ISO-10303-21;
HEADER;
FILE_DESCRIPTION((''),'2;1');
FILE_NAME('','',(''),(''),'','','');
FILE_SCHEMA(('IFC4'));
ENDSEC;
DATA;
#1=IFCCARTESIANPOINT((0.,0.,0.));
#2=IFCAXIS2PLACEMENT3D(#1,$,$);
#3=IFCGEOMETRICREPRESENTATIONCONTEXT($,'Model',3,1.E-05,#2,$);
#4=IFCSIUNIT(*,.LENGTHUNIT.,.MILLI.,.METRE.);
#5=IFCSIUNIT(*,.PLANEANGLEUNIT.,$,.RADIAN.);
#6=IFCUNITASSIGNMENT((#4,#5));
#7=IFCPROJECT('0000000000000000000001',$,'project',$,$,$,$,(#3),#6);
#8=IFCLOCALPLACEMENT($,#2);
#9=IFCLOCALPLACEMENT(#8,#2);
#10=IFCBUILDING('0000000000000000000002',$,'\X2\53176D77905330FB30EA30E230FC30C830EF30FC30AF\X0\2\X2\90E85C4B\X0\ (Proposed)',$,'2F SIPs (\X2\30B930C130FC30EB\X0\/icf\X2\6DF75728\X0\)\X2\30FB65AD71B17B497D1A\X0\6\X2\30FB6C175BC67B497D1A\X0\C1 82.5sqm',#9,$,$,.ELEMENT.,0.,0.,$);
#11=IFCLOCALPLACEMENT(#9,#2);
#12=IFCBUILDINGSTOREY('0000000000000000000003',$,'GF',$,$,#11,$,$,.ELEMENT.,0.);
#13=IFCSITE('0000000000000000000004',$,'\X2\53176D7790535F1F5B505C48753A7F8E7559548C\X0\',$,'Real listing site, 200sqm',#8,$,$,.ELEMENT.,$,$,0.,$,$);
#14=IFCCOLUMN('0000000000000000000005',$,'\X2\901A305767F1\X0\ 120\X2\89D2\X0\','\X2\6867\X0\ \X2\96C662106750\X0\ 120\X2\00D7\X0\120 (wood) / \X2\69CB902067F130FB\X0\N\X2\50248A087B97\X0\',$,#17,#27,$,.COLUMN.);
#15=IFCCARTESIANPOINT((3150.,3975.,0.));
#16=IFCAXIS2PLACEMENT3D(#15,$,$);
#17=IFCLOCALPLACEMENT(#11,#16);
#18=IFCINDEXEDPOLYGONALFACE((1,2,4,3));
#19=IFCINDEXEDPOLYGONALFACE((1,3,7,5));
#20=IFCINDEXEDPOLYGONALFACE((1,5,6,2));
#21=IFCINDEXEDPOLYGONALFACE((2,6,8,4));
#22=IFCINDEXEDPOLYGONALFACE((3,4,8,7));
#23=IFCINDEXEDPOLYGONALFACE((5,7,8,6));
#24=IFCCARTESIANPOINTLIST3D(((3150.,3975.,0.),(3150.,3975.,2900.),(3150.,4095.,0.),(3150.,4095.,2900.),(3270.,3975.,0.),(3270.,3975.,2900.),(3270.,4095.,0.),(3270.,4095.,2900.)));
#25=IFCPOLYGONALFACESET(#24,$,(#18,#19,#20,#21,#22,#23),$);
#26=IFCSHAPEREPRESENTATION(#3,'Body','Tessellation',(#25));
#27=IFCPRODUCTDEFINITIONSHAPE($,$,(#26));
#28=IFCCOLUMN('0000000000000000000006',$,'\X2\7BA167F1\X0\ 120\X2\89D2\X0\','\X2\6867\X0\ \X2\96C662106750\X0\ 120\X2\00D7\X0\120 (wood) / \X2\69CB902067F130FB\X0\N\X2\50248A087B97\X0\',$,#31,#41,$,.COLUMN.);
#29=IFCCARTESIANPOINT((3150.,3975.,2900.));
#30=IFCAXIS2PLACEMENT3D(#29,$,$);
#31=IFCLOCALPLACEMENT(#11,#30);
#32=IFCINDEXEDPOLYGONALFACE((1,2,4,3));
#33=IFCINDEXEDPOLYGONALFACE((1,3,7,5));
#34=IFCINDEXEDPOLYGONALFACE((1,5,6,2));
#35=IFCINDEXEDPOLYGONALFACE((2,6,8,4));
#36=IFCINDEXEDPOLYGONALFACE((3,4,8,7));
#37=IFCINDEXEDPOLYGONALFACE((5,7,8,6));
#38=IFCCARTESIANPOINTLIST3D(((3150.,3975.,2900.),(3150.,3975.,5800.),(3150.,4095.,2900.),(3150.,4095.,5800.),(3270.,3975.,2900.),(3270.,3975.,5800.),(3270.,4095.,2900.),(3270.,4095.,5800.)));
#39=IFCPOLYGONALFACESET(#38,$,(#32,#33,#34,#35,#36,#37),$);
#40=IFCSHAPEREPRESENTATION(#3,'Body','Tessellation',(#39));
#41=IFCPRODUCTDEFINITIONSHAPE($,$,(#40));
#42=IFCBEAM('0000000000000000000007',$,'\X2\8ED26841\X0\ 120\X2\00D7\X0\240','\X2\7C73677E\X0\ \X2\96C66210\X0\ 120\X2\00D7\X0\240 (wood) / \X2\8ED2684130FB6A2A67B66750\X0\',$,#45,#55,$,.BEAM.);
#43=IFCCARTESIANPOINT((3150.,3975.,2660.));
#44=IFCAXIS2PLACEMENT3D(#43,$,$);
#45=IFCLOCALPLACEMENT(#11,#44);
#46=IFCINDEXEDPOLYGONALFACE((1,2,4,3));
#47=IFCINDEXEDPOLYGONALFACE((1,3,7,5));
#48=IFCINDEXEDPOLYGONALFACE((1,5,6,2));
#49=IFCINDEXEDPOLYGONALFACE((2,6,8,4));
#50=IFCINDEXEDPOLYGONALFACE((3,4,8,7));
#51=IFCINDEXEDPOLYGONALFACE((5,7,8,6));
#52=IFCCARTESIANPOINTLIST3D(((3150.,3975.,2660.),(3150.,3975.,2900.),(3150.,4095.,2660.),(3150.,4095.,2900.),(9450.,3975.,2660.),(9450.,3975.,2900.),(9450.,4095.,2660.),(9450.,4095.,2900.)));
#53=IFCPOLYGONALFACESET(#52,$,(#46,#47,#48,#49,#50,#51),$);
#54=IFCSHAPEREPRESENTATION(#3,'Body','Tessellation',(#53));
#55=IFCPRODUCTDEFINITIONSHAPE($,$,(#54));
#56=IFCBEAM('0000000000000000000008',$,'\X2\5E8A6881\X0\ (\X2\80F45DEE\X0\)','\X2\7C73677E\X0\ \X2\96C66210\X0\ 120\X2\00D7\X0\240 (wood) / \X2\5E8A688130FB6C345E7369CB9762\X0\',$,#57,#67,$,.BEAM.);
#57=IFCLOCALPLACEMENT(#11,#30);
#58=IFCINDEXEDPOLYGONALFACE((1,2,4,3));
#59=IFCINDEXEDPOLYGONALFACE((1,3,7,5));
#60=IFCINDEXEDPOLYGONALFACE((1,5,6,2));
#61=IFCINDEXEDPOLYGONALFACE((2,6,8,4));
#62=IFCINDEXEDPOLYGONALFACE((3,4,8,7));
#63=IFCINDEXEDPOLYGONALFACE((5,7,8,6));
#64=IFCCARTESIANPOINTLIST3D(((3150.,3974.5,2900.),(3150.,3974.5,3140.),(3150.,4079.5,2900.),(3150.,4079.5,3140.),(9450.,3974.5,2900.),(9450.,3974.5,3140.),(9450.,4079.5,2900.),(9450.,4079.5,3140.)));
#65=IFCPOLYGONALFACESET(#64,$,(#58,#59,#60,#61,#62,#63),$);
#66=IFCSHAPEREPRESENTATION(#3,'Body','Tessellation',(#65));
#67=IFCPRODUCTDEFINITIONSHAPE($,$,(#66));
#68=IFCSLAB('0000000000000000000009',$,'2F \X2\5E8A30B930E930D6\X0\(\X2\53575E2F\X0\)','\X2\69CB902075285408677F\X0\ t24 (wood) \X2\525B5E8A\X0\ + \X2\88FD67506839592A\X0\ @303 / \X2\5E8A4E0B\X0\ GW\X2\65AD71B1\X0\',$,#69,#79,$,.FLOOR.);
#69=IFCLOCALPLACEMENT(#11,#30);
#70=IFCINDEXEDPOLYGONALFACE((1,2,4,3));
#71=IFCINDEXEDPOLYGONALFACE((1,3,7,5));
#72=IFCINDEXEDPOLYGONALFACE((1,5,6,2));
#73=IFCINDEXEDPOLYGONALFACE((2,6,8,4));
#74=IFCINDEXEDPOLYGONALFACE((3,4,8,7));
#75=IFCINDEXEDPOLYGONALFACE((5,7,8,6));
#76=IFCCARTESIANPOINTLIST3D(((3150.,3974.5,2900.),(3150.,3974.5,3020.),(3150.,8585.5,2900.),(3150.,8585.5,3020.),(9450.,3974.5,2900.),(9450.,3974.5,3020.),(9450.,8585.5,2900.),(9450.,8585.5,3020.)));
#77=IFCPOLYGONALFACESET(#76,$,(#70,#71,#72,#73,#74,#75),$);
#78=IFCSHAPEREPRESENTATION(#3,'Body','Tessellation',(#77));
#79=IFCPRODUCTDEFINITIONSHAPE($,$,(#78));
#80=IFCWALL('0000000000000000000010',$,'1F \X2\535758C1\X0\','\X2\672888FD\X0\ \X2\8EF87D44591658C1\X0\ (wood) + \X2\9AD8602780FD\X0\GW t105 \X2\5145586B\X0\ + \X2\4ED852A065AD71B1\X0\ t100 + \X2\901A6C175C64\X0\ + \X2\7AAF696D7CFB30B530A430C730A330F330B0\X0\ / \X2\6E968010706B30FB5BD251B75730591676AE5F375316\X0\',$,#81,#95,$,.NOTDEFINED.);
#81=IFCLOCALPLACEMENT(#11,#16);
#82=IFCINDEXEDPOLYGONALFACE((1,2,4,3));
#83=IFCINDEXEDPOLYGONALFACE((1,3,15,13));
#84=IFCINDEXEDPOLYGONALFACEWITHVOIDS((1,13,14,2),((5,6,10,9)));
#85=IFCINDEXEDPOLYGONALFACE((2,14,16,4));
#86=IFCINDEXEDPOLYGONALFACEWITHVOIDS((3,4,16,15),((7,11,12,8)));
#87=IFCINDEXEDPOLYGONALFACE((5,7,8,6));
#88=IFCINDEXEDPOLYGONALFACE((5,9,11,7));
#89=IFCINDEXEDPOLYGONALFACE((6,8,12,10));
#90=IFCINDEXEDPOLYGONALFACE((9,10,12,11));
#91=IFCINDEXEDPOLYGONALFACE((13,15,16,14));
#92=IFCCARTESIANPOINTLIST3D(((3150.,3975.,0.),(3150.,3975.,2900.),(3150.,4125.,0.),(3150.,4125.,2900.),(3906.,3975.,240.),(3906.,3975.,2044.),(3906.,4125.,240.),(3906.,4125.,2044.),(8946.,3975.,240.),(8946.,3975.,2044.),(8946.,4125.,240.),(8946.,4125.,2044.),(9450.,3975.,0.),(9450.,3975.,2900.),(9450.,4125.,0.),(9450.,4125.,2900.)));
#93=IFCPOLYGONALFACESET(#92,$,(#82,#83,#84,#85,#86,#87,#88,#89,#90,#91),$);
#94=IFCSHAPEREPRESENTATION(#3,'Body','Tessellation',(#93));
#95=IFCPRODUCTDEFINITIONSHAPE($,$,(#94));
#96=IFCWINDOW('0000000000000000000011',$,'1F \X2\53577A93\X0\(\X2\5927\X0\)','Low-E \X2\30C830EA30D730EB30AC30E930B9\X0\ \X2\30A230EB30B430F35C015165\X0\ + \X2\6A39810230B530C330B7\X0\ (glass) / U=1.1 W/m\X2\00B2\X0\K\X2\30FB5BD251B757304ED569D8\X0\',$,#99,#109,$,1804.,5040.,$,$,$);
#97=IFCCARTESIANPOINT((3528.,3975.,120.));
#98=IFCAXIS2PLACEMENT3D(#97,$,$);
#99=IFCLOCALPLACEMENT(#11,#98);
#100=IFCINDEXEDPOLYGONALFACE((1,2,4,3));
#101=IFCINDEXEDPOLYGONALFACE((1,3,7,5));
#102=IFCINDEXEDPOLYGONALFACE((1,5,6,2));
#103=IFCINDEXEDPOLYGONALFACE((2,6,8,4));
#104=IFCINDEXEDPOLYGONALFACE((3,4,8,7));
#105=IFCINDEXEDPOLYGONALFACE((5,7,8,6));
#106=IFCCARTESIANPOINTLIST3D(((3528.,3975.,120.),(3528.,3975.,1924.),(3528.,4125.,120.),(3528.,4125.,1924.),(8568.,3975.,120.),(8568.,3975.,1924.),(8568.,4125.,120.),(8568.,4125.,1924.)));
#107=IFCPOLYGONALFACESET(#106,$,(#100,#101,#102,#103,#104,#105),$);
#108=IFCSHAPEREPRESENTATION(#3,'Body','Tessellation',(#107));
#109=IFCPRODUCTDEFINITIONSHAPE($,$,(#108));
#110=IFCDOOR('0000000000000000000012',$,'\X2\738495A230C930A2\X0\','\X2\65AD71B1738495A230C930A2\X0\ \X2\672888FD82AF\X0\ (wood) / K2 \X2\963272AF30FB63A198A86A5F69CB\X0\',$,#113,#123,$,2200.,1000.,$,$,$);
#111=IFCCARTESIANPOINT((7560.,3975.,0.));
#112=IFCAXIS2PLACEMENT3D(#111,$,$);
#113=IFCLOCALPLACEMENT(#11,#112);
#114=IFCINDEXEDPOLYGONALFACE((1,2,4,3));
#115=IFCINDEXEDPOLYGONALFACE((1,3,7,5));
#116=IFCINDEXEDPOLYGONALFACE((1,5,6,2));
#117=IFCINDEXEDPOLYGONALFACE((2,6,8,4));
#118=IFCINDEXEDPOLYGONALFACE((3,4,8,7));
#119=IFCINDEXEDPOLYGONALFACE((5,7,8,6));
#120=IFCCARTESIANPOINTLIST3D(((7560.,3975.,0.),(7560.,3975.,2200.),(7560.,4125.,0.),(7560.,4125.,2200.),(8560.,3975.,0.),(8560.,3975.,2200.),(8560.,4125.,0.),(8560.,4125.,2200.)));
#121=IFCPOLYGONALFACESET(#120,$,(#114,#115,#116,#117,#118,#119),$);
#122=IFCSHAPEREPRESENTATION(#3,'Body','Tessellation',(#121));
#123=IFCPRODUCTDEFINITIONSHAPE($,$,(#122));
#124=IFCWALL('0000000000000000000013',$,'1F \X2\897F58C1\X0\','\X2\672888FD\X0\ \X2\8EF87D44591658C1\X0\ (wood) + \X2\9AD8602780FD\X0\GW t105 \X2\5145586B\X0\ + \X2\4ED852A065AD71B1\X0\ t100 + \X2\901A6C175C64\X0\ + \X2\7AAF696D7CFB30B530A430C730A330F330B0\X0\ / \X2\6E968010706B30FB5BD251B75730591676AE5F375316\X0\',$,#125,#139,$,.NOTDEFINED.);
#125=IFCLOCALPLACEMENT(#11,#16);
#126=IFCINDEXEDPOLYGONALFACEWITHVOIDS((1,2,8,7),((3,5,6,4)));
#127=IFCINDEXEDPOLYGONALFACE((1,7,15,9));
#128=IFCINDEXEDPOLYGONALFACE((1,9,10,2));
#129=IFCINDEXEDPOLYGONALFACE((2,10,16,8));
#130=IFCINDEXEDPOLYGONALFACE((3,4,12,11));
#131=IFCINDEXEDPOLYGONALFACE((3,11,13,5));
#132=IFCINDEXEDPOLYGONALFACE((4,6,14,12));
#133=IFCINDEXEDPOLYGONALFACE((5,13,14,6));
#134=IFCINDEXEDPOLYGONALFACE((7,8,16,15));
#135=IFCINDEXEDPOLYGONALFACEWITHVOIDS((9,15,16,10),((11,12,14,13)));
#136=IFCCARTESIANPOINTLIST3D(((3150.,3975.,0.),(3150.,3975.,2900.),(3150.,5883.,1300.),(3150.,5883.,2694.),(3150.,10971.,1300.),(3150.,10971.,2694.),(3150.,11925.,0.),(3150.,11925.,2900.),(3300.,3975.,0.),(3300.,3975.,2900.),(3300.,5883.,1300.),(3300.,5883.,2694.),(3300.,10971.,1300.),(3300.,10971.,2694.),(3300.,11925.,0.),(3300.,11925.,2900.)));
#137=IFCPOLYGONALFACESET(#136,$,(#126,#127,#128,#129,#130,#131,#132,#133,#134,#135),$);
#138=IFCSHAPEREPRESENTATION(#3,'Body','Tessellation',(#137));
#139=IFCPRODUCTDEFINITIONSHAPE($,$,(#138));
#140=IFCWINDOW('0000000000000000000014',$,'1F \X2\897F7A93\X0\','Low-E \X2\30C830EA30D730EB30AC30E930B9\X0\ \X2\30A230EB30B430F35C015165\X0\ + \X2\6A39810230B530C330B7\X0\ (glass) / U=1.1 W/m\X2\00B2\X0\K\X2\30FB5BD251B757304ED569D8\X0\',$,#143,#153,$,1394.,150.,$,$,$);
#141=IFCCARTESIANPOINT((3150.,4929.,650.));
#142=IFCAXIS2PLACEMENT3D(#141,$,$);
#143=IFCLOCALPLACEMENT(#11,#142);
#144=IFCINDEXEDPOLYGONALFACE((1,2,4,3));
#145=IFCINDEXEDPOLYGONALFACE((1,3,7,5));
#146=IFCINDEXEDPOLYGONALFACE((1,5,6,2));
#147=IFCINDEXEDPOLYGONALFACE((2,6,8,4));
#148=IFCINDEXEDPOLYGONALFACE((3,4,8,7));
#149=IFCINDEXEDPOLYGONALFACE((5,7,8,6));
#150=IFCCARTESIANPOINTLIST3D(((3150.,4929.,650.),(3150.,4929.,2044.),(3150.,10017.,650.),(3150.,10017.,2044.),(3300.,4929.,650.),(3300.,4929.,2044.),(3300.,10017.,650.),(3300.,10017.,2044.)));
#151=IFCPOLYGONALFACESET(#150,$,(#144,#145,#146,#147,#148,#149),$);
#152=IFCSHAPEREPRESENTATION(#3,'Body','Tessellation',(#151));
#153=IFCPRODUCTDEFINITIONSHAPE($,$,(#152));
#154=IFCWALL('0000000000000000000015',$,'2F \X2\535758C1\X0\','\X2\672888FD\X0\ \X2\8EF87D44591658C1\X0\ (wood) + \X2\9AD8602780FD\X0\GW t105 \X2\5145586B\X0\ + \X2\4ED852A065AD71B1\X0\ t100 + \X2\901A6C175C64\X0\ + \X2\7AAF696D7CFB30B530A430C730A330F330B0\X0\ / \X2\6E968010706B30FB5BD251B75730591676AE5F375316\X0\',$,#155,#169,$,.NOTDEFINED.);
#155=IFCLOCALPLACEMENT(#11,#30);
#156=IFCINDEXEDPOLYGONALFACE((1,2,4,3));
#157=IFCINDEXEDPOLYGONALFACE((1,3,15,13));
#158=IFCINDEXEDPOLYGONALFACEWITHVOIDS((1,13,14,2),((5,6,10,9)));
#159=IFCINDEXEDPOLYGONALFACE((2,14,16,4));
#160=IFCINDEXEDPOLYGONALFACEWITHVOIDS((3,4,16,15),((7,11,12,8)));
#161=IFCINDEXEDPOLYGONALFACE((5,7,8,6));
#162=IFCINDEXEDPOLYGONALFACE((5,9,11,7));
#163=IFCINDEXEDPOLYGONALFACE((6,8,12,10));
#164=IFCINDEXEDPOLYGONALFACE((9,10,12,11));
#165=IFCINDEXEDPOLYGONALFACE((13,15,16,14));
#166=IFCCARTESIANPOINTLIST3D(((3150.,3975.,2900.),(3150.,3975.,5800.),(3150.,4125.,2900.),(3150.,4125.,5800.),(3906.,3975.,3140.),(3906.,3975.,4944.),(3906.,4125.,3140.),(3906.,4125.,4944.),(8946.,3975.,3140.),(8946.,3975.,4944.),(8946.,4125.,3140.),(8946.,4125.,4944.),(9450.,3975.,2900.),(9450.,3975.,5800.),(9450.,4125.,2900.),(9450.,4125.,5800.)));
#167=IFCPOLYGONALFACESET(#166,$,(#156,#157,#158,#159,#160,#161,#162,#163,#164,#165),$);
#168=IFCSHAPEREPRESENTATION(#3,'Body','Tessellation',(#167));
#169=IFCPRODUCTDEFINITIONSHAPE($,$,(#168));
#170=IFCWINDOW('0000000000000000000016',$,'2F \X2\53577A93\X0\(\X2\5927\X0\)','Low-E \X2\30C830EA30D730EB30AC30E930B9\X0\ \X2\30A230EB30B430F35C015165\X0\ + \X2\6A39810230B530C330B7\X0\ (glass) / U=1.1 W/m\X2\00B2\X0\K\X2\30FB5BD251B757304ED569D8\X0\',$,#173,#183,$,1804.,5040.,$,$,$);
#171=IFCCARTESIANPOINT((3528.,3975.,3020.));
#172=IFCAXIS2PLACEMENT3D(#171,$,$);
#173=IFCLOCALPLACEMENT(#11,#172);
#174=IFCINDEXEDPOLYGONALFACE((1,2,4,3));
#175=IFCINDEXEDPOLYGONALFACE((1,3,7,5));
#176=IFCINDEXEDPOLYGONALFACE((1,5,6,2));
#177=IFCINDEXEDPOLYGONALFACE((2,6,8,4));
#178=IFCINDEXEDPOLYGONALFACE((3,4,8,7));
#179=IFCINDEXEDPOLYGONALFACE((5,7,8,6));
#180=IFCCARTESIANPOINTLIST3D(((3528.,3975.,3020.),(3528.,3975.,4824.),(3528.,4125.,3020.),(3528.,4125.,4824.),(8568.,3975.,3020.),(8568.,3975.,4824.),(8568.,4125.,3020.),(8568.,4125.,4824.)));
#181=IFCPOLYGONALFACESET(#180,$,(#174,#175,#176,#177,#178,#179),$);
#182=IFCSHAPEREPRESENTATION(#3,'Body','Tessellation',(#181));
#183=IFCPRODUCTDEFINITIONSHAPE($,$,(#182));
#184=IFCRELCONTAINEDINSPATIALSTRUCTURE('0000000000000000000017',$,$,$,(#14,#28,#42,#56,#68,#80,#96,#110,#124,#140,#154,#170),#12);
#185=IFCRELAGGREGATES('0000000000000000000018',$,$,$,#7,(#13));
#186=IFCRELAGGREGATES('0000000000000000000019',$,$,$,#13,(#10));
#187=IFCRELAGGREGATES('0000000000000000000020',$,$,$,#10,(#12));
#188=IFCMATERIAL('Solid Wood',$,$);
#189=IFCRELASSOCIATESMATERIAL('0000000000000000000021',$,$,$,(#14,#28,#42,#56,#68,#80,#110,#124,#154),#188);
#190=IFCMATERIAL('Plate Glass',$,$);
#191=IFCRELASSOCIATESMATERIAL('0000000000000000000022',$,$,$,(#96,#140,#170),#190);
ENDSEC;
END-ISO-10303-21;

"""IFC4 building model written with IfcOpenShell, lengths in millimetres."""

from ifc_helpers import new_model, si_unit, frame, frame_2d, origin, place, context, project, spatial, rectangle, extrude, material, element, fill, save


model = new_model("IFC4")

# Units and contexts
model_context = context("Model", 3, precision=1e-05, world=origin())
ifc_project = project(units=[si_unit("LENGTHUNIT", "METRE", prefix="MILLI"), si_unit("PLANEANGLEUNIT", "RADIAN")], contexts=[model_context])

# Site, building, storey
site_placement = place(None, origin())
site = spatial("IfcSite", under=ifc_project, at=site_placement, Name="北海道弟子屈町美留和", ObjectType="Real listing site, 200sqm", CompositionType="ELEMENT", RefElevation=0.0)
building_placement = place(site_placement, origin())
building = spatial("IfcBuilding", under=site, at=building_placement, Name="北海道・リモートワーク2部屋 (Proposed)", ObjectType="2F SIPs (スチール/icf混在)・断熱等級6・気密等級C1 82.5sqm", CompositionType="ELEMENT", ElevationOfRefHeight=0.0, ElevationOfTerrain=0.0)
storey_placement = place(building_placement, origin())
storey = spatial("IfcBuildingStorey", under=building, at=storey_placement, Name="GF", CompositionType="ELEMENT", Elevation=0.0)

# Columns
ifc_material_1 = material(Name="Solid Wood")
column_1_placement = place(storey_placement, frame((3150.0, 3975.0, 0.0)))
element("IfcColumn", 1, at=column_1_placement, inside=storey, material=ifc_material_1, Name="通し柱 120角", Description="桧 集成材 120×120 (wood) / 構造柱・N値計算", PredefinedType="COLUMN", context=model_context, shape_type="SweptSolid", body=[
    extrude(rectangle(XDim=120.0, YDim=120.0, at=frame_2d((60.0, 60.0))), frame((3150.0, 3975.0, 0.0)), (0.0, 0.0, 1.0), 2900.0),
])
column_2_placement = place(storey_placement, frame((3150.0, 3975.0, 2900.0)))
element("IfcColumn", 2, at=column_2_placement, inside=storey, material=ifc_material_1, Name="管柱 120角", Description="桧 集成材 120×120 (wood) / 構造柱・N値計算", PredefinedType="COLUMN", context=model_context, shape_type="SweptSolid", body=[
    extrude(rectangle(XDim=120.0, YDim=120.0, at=frame_2d((60.0, 60.0))), frame((3150.0, 3975.0, 2900.0)), (0.0, 0.0, 1.0), 2900.0),
])

# Beams
beam_1_placement = place(storey_placement, frame((3150.0, 3975.0, 2660.0)))
element("IfcBeam", 3, at=beam_1_placement, inside=storey, material=ifc_material_1, Name="軒桁 120×240", Description="米松 集成 120×240 (wood) / 軒桁・横架材", PredefinedType="BEAM", context=model_context, shape_type="SweptSolid", body=[
    extrude(rectangle(XDim=6300.0, YDim=120.0, at=frame_2d((3150.0, 60.0))), frame((3150.0, 3975.0, 2660.0)), (0.0, 0.0, 1.0), 240.0),
])
beam_2_placement = place(storey_placement, frame((3150.0, 3975.0, 2900.0)))
element("IfcBeam", 4, at=beam_2_placement, inside=storey, material=ifc_material_1, Name="床梁 (胴差)", Description="米松 集成 120×240 (wood) / 床梁・水平構面", PredefinedType="BEAM", context=model_context, shape_type="SweptSolid", body=[
    extrude(rectangle(XDim=6300.0, YDim=105.0, at=frame_2d((3150.0, 52.0))), frame((3150.0, 3975.0, 2900.0)), (0.0, 0.0, 1.0), 240.0),
])

# Slab
slab_1_placement = place(storey_placement, frame((3150.0, 3975.0, 2900.0)))
element("IfcSlab", 5, at=slab_1_placement, inside=storey, material=ifc_material_1, Name="2F 床スラブ(南帯)", Description="構造用合板 t24 (wood) 剛床 + 製材根太 @303 / 床下 GW断熱", PredefinedType="FLOOR", context=model_context, shape_type="SweptSolid", body=[
    extrude(rectangle(XDim=6300.0, YDim=4611.0, at=frame_2d((3150.0, 2305.0))), frame((3150.0, 3975.0, 2900.0)), (0.0, 0.0, 1.0), 120.0),
])

# Wall, openings, window, door
wall_1_placement = place(storey_placement, frame((3150.0, 3975.0, 0.0)))
wall_1 = element("IfcWall", 6, at=wall_1_placement, inside=storey, material=ifc_material_1, Name="1F 南壁", Description="木製 軸組外壁 (wood) + 高性能GW t105 充填 + 付加断熱 t100 + 通気層 + 窯業系サイディング / 準耐火・寒冷地外皮強化", PredefinedType="NOTDEFINED", context=model_context, shape_type="SweptSolid", body=[
    extrude(rectangle(XDim=6300.0, YDim=150.0, at=frame_2d((3150.0, 75.0))), frame((3150.0, 3975.0, 0.0)), (0.0, 0.0, 1.0), 2900.0),
])
opening_1_placement = place(storey_placement, frame((3528.0, 3975.0, 120.0)))
opening_1 = element("IfcOpeningElement", 7, at=opening_1_placement, cuts=wall_1, PredefinedType="NOTDEFINED", context=model_context, shape_type="SweptSolid", body=[
    extrude(rectangle(XDim=5040.0, YDim=150.0, at=frame_2d((2520.0, 75.0))), frame((3528.0, 3975.0, 120.0)), (0.0, 0.0, 1.0), 1804.0),
])
opening_2_placement = place(storey_placement, frame((7560.0, 3975.0, 0.0)))
opening_2 = element("IfcOpeningElement", 8, at=opening_2_placement, cuts=wall_1, PredefinedType="NOTDEFINED", context=model_context, shape_type="SweptSolid", body=[
    extrude(rectangle(XDim=1000.0, YDim=150.0, at=frame_2d((500.0, 75.0))), frame((7560.0, 3975.0, 0.0)), (0.0, 0.0, 1.0), 2200.0),
])
ifc_material_2 = material(Name="Plate Glass")
window_1_placement = place(storey_placement, frame((3528.0, 3975.0, 120.0)))
window_1 = element("IfcWindow", 9, at=window_1_placement, inside=storey, material=ifc_material_2, Name="1F 南窓(大)", Description="Low-E トリプルガラス アルゴン封入 + 樹脂サッシ (glass) / U=1.1 W/m²K・寒冷地仕様", OverallHeight=1804.0, OverallWidth=5040.0, context=model_context, shape_type="SweptSolid", body=[
    extrude(rectangle(XDim=5040.0, YDim=150.0, at=frame_2d((2520.0, 75.0))), frame((3528.0, 3975.0, 120.0)), (0.0, 0.0, 1.0), 1804.0),
])
fill(opening_1, window_1)
door_placement = place(storey_placement, frame((7560.0, 3975.0, 0.0)))
door = element("IfcDoor", 10, at=door_placement, inside=storey, material=ifc_material_1, Name="玄関ドア", Description="断熱玄関ドア 木製芯 (wood) / K2 防犯・採風機構", OverallHeight=2200.0, OverallWidth=1000.0, context=model_context, shape_type="SweptSolid", body=[
    extrude(rectangle(XDim=1000.0, YDim=150.0, at=frame_2d((500.0, 75.0))), frame((7560.0, 3975.0, 0.0)), (0.0, 0.0, 1.0), 2200.0),
])
fill(opening_2, door)

# Walls, openings, windows
wall_2_placement = place(storey_placement, frame((3150.0, 3975.0, 0.0)))
wall_2 = element("IfcWall", 11, at=wall_2_placement, inside=storey, material=ifc_material_1, Name="1F 西壁", Description="木製 軸組外壁 (wood) + 高性能GW t105 充填 + 付加断熱 t100 + 通気層 + 窯業系サイディング / 準耐火・寒冷地外皮強化", PredefinedType="NOTDEFINED", context=model_context, shape_type="SweptSolid", body=[
    extrude(rectangle(XDim=150.0, YDim=7950.0, at=frame_2d((75.0, 3975.0))), frame((3150.0, 3975.0, 0.0)), (0.0, 0.0, 1.0), 2900.0),
])
opening_3_placement = place(storey_placement, frame((3150.0, 4929.0, 650.0)))
opening_3 = element("IfcOpeningElement", 12, at=opening_3_placement, cuts=wall_2, PredefinedType="NOTDEFINED", context=model_context, shape_type="SweptSolid", body=[
    extrude(rectangle(XDim=150.0, YDim=5088.0, at=frame_2d((75.0, 2544.0))), frame((3150.0, 4929.0, 650.0)), (0.0, 0.0, 1.0), 1394.0),
])
window_2_placement = place(storey_placement, frame((3150.0, 4929.0, 650.0)))
window_2 = element("IfcWindow", 13, at=window_2_placement, inside=storey, material=ifc_material_2, Name="1F 西窓", Description="Low-E トリプルガラス アルゴン封入 + 樹脂サッシ (glass) / U=1.1 W/m²K・寒冷地仕様", OverallHeight=1394.0, OverallWidth=150.0, context=model_context, shape_type="SweptSolid", body=[
    extrude(rectangle(XDim=150.0, YDim=5088.0, at=frame_2d((75.0, 2544.0))), frame((3150.0, 4929.0, 650.0)), (0.0, 0.0, 1.0), 1394.0),
])
fill(opening_3, window_2)
wall_3_placement = place(storey_placement, frame((3150.0, 3975.0, 2900.0)))
wall_3 = element("IfcWall", 14, at=wall_3_placement, inside=storey, material=ifc_material_1, Name="2F 南壁", Description="木製 軸組外壁 (wood) + 高性能GW t105 充填 + 付加断熱 t100 + 通気層 + 窯業系サイディング / 準耐火・寒冷地外皮強化", PredefinedType="NOTDEFINED", context=model_context, shape_type="SweptSolid", body=[
    extrude(rectangle(XDim=6300.0, YDim=150.0, at=frame_2d((3150.0, 75.0))), frame((3150.0, 3975.0, 2900.0)), (0.0, 0.0, 1.0), 2900.0),
])
opening_4_placement = place(storey_placement, frame((3528.0, 3975.0, 3020.0)))
opening_4 = element("IfcOpeningElement", 15, at=opening_4_placement, cuts=wall_3, PredefinedType="NOTDEFINED", context=model_context, shape_type="SweptSolid", body=[
    extrude(rectangle(XDim=5040.0, YDim=150.0, at=frame_2d((2520.0, 75.0))), frame((3528.0, 3975.0, 3020.0)), (0.0, 0.0, 1.0), 1804.0),
])
window_3_placement = place(storey_placement, frame((3528.0, 3975.0, 3020.0)))
window_3 = element("IfcWindow", 16, at=window_3_placement, inside=storey, material=ifc_material_2, Name="2F 南窓(大)", Description="Low-E トリプルガラス アルゴン封入 + 樹脂サッシ (glass) / U=1.1 W/m²K・寒冷地仕様", OverallHeight=1804.0, OverallWidth=5040.0, context=model_context, shape_type="SweptSolid", body=[
    extrude(rectangle(XDim=5040.0, YDim=150.0, at=frame_2d((2520.0, 75.0))), frame((3528.0, 3975.0, 3020.0)), (0.0, 0.0, 1.0), 1804.0),
])
fill(opening_4, window_3)

save(model, "model.ifc")
